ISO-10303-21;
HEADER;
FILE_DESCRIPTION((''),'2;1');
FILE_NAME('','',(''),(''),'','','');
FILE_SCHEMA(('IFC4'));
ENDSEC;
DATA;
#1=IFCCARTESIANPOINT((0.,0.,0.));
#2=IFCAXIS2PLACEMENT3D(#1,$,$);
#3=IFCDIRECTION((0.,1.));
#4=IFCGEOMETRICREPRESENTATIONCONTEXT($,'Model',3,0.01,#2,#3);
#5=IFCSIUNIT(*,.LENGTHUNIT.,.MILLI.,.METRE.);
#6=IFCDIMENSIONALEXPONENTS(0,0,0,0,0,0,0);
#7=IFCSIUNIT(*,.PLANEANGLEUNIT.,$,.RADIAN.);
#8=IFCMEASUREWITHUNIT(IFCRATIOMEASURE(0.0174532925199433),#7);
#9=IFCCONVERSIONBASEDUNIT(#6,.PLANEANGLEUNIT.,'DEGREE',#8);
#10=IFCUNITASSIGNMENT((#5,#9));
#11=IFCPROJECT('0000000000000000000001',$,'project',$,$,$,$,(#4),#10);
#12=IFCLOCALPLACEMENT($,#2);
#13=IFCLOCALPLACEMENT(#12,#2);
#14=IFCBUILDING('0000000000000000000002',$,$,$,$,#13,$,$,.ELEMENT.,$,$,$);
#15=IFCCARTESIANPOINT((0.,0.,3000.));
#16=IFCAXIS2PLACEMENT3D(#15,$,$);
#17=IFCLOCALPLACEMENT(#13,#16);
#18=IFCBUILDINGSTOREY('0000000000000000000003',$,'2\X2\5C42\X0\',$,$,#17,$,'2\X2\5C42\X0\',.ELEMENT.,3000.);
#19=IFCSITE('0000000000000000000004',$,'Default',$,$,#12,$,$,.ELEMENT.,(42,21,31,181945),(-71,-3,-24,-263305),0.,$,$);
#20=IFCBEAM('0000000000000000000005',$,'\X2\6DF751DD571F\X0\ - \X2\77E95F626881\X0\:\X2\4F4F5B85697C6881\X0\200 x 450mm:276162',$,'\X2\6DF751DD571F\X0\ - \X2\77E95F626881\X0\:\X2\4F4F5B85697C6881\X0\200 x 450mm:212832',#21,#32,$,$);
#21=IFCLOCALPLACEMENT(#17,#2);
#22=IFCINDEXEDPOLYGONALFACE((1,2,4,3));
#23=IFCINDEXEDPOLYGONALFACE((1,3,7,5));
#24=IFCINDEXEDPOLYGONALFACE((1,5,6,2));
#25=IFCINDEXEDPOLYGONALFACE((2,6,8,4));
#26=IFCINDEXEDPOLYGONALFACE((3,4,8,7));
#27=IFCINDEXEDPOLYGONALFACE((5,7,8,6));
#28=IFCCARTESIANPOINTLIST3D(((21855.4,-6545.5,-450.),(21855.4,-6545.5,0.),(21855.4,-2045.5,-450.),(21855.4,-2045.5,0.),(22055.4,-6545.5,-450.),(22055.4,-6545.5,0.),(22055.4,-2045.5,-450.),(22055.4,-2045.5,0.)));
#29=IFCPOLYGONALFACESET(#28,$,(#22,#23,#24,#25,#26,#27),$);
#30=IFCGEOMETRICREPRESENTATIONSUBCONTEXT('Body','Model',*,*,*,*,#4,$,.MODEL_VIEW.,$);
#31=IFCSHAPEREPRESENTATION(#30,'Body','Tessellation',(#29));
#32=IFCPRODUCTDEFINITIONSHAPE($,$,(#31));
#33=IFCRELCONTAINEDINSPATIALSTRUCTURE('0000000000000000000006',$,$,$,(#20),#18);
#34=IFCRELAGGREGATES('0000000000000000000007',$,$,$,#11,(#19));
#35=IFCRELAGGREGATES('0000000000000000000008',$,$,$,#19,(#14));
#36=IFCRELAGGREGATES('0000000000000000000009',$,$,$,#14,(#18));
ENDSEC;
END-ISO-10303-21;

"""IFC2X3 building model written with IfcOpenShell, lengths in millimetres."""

from ifc_helpers import new_model, entity, si_unit, converted_unit, direction, frame, frame_2d, origin, place, context, subcontext, project, spatial, rectangle, extrude, element, save


model = new_model("IFC2X3")

# Units and contexts
model_context = context("Model", 3, precision=0.01, world=origin(), true_north=direction((0.0, 1.0)))
body_context = subcontext(model_context, "Body", "Model", "MODEL_VIEW")
ifc_project = project(units=[si_unit("LENGTHUNIT", "METRE", prefix="MILLI"), converted_unit("PLANEANGLEUNIT", "DEGREE", entity("IfcRatioMeasure", 0.0174532925199433), si_unit("PLANEANGLEUNIT", "RADIAN"), dimensions=[0, 0, 0, 0, 0, 0, 0])], contexts=[model_context])

# Site, building, storey
site_placement = place(None, origin())
site = spatial("IfcSite", under=ifc_project, at=site_placement, Name="Default", CompositionType="ELEMENT", RefLatitude=(42, 21, 31, 181945), RefLongitude=(-71, -3, -24, -263305), RefElevation=0.0)
building_placement = place(site_placement, origin())
building = spatial("IfcBuilding", under=site, at=building_placement, CompositionType="ELEMENT")
storey_placement = place(building_placement, frame((0.0, 0.0, 3000.0)))
storey = spatial("IfcBuildingStorey", under=building, at=storey_placement, Name="2层", LongName="2层", CompositionType="ELEMENT", Elevation=3000.0)

# Beam
beam_1_placement = place(storey_placement, frame((21955.4, -1945.5, 0.0), z_axis=(0.0, 0.0, 1.0), x_axis=(0.0, -1.0, 0.0)))
element("IfcBeam", 1, at=beam_1_placement, inside=storey, Name="混凝土 - 矩形梁:住宅楼梁200 x 450mm:276162", ObjectType="混凝土 - 矩形梁:住宅楼梁200 x 450mm:212832", context=body_context, shape_type="SweptSolid", body=[
    extrude(rectangle(XDim=450.0, YDim=200.0, at=frame_2d((0.0, 0.0), x_axis=(1.0, 0.0))), frame((100.0, 0.0, -225.0), z_axis=(1.0, 0.0, 0.0), x_axis=(0.0, 0.0, -1.0)), (0.0, 0.0, 1.0), 4500.0),
])

save(model, "model.ifc")
